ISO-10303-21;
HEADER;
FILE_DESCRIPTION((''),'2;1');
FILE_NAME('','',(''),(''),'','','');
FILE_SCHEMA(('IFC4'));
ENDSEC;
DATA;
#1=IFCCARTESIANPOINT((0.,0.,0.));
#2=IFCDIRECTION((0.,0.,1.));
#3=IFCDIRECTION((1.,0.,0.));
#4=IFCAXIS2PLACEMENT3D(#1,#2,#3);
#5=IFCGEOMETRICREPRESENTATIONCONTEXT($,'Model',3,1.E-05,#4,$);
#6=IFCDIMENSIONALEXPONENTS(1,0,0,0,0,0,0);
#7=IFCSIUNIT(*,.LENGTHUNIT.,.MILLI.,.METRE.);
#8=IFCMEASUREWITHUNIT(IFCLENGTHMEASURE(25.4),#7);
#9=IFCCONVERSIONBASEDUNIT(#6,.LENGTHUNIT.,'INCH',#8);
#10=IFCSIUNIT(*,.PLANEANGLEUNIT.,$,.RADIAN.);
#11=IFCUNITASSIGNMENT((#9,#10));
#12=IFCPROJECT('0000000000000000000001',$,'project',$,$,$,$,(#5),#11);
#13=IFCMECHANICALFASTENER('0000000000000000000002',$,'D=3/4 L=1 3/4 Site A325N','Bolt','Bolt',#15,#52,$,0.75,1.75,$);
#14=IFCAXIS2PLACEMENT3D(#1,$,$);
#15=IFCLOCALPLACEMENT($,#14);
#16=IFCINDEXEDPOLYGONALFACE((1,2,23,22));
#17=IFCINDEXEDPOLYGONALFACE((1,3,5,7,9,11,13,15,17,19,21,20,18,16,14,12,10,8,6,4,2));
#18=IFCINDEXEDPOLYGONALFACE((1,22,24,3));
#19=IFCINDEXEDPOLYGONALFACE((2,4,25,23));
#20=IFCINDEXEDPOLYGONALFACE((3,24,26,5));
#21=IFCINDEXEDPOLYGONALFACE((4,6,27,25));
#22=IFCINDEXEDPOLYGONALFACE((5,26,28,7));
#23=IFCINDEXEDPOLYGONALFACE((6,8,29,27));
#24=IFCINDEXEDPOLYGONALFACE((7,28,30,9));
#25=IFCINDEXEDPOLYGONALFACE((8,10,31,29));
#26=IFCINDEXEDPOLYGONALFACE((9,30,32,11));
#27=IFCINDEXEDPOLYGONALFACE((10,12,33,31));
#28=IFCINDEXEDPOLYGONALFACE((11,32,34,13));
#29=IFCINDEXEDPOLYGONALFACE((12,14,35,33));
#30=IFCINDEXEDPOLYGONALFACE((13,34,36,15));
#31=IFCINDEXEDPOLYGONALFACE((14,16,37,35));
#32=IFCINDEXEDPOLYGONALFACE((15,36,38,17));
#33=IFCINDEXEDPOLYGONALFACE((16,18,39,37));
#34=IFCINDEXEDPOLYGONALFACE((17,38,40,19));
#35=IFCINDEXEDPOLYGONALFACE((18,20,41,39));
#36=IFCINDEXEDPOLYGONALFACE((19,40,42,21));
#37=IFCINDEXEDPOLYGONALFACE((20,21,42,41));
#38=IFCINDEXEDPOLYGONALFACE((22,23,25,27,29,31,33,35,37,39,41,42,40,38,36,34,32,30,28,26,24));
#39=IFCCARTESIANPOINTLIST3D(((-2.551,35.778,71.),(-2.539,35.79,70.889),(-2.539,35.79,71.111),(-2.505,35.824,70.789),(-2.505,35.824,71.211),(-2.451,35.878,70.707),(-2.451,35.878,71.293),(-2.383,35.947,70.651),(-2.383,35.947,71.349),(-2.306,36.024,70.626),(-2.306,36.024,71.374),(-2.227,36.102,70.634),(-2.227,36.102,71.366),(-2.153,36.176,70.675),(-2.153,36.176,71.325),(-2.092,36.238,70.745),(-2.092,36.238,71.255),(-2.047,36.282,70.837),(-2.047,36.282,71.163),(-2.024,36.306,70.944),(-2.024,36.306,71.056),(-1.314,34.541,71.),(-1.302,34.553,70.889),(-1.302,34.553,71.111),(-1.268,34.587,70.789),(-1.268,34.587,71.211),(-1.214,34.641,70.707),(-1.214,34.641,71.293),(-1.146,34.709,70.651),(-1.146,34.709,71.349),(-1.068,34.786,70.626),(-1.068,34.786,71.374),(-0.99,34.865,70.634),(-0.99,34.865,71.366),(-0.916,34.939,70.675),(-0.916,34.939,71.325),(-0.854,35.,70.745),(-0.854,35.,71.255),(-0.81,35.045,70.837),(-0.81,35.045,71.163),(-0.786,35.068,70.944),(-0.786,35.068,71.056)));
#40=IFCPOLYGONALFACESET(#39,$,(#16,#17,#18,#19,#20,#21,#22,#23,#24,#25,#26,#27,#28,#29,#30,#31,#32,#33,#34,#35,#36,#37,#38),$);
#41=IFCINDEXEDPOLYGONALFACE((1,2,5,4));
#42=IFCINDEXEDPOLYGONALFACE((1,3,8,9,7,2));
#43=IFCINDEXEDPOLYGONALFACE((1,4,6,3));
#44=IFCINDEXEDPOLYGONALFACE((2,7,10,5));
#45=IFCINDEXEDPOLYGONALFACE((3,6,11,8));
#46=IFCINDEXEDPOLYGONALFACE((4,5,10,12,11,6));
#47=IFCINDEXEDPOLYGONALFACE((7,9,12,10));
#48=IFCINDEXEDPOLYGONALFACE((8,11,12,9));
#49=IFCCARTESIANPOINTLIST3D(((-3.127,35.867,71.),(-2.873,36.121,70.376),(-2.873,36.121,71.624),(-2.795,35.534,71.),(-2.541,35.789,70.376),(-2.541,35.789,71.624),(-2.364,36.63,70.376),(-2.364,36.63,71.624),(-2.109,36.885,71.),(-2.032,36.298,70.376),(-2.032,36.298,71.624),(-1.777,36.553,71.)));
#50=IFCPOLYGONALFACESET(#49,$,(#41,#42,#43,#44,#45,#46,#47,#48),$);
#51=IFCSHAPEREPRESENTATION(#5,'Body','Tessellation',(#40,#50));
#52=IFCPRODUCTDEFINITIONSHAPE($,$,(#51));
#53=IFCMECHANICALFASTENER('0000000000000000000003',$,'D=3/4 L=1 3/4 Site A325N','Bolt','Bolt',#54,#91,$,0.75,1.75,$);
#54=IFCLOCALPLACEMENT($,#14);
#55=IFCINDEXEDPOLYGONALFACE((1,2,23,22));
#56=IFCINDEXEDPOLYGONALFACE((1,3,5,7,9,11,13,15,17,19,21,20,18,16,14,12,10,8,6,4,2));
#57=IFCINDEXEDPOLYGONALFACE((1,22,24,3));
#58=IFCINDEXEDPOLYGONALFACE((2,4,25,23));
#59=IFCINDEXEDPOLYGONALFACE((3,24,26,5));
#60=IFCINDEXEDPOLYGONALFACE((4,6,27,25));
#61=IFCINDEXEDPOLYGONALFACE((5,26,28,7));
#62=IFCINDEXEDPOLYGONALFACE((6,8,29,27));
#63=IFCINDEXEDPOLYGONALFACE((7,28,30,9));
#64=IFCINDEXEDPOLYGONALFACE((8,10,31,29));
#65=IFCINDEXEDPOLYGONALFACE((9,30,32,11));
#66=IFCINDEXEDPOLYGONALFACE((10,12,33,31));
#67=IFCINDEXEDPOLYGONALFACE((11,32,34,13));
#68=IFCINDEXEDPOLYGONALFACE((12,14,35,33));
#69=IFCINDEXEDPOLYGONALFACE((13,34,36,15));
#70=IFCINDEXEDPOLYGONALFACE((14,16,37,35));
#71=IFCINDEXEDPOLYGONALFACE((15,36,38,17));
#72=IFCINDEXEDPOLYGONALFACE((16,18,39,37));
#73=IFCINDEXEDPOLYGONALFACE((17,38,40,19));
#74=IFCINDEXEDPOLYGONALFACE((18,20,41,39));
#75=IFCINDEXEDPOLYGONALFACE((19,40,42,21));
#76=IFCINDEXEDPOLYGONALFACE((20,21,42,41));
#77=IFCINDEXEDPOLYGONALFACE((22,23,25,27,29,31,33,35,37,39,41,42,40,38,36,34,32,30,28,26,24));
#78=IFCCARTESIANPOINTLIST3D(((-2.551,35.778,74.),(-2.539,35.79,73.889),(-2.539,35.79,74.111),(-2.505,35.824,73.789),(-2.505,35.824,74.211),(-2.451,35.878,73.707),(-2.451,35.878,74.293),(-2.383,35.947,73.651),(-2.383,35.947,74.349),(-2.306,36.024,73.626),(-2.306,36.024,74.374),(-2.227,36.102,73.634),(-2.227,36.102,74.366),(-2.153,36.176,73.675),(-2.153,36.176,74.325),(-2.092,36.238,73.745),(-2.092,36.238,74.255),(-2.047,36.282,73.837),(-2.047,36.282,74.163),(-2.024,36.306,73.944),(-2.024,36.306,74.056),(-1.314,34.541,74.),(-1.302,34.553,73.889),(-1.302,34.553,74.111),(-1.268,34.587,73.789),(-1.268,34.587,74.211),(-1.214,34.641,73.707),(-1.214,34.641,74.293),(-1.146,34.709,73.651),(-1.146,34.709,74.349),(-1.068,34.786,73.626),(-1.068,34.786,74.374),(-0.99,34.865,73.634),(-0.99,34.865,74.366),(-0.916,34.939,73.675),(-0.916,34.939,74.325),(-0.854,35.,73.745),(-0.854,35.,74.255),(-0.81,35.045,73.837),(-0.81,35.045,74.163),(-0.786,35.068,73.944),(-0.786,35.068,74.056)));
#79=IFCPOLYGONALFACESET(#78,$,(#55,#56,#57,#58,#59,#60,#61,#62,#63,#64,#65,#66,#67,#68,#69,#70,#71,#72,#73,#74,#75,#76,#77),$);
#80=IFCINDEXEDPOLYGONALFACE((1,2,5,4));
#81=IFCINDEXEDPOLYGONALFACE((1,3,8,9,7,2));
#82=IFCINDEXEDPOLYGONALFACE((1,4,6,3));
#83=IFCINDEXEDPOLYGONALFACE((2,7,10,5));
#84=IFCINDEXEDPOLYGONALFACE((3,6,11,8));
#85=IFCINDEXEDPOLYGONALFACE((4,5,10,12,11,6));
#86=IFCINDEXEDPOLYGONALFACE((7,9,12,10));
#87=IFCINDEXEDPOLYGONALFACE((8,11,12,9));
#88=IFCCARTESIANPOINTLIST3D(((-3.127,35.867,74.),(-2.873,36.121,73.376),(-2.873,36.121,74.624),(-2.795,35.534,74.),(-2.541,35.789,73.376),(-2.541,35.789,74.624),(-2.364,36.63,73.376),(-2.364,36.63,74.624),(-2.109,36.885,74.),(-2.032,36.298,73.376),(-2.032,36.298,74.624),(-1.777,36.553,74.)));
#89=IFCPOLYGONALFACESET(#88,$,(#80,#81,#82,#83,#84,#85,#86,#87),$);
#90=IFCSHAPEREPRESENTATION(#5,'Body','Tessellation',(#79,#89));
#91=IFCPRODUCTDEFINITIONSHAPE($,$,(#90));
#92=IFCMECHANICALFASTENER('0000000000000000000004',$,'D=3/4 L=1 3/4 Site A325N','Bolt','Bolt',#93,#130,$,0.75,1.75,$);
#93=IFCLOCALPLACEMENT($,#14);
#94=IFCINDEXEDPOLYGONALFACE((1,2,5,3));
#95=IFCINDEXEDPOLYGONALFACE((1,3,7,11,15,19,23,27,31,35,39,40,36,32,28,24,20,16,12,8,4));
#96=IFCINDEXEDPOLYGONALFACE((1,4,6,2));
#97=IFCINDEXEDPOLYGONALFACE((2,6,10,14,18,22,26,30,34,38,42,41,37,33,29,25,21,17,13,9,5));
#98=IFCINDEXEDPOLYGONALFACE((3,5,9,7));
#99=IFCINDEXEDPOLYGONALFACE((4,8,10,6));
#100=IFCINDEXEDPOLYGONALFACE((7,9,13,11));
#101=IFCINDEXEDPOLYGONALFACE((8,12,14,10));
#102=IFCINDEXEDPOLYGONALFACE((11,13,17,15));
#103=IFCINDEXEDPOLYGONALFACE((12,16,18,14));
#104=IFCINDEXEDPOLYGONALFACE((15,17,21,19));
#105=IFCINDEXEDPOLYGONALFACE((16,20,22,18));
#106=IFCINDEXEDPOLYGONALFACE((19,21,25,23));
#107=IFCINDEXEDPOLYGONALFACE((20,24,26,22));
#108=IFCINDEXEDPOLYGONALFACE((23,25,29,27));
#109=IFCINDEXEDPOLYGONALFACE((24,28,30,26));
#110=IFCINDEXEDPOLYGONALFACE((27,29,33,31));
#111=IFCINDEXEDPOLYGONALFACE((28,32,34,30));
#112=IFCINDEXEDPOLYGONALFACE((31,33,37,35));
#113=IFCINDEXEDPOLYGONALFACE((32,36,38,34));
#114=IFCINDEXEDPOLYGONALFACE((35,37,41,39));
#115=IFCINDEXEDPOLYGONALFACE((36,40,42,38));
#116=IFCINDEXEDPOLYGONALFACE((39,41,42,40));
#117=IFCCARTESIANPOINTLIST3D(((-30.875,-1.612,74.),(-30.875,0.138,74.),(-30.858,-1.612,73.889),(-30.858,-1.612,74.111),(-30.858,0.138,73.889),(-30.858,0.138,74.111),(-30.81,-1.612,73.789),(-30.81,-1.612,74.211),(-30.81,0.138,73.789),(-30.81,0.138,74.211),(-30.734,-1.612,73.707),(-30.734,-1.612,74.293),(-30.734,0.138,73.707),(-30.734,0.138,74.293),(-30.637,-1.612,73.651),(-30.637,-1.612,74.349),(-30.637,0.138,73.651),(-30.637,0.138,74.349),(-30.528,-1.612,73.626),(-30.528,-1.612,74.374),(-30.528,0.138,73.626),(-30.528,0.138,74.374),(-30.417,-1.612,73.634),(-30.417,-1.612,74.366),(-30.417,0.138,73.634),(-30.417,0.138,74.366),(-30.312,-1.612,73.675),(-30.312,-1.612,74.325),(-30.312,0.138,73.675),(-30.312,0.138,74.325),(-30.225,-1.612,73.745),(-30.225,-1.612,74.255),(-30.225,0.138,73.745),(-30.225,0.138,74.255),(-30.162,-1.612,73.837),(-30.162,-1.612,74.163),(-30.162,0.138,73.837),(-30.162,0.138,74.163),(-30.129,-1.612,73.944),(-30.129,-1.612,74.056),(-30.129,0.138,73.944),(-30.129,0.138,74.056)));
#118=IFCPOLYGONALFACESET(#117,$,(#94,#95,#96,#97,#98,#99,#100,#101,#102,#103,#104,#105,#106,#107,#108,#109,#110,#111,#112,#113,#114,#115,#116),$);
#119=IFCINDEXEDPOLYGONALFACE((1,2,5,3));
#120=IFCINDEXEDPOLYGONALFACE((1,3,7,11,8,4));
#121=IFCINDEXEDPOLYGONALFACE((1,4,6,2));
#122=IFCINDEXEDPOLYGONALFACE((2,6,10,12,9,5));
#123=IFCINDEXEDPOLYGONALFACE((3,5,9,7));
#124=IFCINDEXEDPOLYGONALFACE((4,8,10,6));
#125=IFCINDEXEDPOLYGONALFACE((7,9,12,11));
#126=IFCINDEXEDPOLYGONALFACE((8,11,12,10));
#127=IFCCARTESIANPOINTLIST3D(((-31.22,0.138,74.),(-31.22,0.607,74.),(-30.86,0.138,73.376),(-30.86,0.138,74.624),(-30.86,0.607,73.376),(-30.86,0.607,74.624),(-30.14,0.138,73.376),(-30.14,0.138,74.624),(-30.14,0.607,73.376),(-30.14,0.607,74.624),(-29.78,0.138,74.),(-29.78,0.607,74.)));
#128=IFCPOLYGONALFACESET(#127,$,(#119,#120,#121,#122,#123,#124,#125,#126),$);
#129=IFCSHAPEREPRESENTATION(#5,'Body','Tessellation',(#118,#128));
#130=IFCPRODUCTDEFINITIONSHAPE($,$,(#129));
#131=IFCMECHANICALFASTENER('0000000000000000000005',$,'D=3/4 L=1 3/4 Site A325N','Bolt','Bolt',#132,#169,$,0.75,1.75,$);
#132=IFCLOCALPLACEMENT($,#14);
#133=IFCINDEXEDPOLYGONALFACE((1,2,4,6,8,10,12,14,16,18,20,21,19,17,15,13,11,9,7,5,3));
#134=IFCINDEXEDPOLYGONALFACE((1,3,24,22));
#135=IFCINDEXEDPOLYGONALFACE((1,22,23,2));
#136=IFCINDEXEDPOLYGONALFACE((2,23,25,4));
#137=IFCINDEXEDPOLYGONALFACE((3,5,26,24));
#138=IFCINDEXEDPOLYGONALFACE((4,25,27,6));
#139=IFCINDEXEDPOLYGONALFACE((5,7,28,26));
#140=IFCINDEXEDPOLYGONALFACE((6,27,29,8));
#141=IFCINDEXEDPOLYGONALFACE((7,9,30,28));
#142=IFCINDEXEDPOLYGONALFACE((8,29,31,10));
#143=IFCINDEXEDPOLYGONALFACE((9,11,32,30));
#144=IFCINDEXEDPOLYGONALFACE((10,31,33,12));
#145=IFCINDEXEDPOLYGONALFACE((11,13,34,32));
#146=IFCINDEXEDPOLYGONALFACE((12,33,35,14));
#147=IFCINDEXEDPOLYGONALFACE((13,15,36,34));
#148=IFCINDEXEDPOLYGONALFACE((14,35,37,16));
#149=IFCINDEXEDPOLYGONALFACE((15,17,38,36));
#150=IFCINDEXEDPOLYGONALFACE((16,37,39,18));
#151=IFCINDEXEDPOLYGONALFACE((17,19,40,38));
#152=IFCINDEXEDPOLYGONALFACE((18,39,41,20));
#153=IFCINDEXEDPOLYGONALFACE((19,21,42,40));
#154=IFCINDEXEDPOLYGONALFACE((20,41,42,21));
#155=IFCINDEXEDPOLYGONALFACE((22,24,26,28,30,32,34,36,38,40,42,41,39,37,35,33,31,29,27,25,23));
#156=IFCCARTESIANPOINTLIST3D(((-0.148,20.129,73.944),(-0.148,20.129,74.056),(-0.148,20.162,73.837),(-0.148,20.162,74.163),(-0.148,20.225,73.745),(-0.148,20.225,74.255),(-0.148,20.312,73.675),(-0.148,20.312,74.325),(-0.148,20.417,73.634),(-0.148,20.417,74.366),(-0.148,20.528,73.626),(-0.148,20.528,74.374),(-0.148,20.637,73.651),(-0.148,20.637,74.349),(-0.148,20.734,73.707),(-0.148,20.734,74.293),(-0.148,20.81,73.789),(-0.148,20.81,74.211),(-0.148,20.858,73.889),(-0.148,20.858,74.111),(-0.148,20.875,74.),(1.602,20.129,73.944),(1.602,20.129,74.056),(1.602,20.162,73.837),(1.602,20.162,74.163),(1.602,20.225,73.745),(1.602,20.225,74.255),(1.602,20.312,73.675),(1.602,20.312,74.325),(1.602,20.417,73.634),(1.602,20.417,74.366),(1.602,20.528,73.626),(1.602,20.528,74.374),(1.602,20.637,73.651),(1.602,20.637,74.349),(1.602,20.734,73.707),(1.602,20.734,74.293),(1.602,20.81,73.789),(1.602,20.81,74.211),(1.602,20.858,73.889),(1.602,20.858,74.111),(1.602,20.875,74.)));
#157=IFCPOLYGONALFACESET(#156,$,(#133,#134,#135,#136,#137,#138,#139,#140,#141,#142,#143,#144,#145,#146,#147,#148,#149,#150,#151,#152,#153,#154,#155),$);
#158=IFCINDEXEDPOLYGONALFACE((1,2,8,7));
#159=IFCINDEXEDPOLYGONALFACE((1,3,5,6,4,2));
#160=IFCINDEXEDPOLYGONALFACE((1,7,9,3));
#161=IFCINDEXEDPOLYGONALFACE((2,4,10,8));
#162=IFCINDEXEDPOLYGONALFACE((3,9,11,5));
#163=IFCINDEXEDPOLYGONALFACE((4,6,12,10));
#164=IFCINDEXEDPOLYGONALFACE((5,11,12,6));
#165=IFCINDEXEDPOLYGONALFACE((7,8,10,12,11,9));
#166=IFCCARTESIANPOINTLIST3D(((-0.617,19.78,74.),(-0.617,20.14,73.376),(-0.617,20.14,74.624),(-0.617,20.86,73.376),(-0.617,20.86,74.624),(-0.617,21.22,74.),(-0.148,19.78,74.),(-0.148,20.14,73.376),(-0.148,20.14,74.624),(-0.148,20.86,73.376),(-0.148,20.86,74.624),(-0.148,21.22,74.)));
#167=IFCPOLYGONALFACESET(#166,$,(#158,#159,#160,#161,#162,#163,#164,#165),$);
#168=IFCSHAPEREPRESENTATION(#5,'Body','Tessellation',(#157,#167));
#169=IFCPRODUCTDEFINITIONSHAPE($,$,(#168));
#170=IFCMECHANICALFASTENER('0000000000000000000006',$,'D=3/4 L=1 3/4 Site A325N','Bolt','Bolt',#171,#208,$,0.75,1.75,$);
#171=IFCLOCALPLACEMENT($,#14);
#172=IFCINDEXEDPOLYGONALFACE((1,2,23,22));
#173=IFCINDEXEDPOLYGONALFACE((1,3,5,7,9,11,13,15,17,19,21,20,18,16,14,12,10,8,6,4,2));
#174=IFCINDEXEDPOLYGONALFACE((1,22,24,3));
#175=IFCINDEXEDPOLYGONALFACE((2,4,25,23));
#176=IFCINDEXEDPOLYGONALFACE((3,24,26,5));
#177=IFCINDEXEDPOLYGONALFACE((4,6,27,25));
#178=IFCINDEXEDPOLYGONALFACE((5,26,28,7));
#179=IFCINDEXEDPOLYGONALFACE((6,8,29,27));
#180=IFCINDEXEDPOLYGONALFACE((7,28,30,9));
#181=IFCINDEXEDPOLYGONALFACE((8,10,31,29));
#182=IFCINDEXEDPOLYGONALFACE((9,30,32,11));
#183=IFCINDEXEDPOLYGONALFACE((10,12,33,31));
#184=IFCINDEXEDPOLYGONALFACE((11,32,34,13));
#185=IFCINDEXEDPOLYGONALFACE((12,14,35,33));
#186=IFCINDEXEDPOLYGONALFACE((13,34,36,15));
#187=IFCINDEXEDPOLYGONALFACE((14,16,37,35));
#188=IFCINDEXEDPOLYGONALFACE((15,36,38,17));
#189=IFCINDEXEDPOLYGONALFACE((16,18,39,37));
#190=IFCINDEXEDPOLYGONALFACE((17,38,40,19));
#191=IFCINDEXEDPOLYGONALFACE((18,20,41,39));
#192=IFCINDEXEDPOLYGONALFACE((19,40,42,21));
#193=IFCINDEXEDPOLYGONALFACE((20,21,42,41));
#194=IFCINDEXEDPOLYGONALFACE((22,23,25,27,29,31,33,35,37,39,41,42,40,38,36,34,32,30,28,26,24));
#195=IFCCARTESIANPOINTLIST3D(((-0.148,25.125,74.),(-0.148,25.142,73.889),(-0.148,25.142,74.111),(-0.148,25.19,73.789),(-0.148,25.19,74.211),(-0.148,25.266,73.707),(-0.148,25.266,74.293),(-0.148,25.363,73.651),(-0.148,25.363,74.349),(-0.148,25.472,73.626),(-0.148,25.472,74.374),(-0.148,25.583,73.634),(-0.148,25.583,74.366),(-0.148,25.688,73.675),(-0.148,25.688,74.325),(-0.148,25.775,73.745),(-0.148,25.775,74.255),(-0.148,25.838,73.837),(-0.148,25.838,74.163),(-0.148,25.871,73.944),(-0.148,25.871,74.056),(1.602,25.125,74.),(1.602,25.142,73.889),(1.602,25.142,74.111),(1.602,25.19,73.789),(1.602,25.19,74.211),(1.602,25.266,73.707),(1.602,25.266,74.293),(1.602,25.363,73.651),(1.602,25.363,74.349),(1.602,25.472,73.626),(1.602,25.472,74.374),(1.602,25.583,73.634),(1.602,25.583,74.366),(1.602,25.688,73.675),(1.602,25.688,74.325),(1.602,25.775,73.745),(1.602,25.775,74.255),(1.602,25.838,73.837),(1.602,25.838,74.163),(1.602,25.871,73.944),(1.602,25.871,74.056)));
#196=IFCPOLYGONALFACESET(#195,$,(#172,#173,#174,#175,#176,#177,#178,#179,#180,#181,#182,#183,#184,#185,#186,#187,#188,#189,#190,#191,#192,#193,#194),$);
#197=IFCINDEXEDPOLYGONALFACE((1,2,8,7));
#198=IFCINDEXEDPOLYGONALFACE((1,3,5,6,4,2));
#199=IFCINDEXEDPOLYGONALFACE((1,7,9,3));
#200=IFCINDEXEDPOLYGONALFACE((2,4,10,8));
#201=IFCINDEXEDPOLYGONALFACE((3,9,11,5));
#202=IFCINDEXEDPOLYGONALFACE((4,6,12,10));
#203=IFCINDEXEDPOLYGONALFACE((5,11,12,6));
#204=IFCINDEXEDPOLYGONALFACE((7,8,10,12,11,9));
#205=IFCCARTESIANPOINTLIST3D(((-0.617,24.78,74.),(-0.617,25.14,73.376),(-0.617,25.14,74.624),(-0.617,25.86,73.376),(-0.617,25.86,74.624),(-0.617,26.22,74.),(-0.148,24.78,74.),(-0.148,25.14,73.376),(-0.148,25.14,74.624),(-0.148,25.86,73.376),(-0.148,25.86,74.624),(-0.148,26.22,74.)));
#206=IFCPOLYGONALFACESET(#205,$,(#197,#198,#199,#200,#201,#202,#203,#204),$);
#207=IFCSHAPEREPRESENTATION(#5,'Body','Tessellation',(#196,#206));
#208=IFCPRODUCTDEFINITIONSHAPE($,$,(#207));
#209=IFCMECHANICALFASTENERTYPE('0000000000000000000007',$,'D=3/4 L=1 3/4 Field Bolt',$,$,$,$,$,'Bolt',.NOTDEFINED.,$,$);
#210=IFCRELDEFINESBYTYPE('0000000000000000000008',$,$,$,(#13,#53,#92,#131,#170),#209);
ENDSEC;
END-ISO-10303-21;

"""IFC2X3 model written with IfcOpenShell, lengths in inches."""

from ifc_helpers import new_model, entity, si_unit, converted_unit, frame, origin_with_axes, origin_2d_with_axis, place, context, project, polyline, circle, outline, extrude, source, transform, mapped, type_object, type_shapes, element, save


model = new_model("IFC2X3")

# Units and contexts
model_context = context("Model", 3, precision=1e-05, world=origin_with_axes())
ifc_project = project(units=[converted_unit("LENGTHUNIT", "INCH", entity("IfcLengthMeasure", 25.4), si_unit("LENGTHUNIT", "METRE", prefix="MILLI"), dimensions=[1, 0, 0, 0, 0, 0, 0]), si_unit("PLANEANGLEUNIT", "RADIAN")], contexts=[model_context])

# Mechanical fasteners
mechanical_fastener_type_1 = type_object("IfcMechanicalFastenerType", Name="D=3/4 L=1 3/4 Field Bolt", ElementType="Bolt")
shared_shape_1 = source(origin_with_axes(), model_context, "Body", "SweptSolid", [
    extrude(circle(Radius=0.375, at=origin_2d_with_axis()), frame((0.0, 0.0, 0.0), z_axis=(1.0, 0.0, 0.0), x_axis=(0.0, 1.0, 0.0)), (0.0, 0.0, 1.0), 1.75),
    extrude(outline(polyline([(-0.72, 0.0), (-0.36, 0.624), (0.36, 0.624), (0.72, 0.0), (0.36, -0.624), (-0.36, -0.624), (-0.72, 0.0)])), frame((0.0, 0.0, 0.0), z_axis=(1.0, 0.0, 0.0), x_axis=(0.0, 1.0, 0.0)), (0.0, 0.0, -1.0), 0.47),
])
type_shapes(mechanical_fastener_type_1, [shared_shape_1])
placement_1 = place(None, origin_with_axes())
placement_2 = place(placement_1, origin_with_axes())
placement_3 = place(placement_2, frame((-38.0, 0.0, 77.0), z_axis=(0.0, 0.0, 1.0), x_axis=(0.707107, 0.707107, 0.0)))
placement_4 = place(placement_3, frame((50.74, 0.233, -3.0), z_axis=(0.0, 0.0, -1.0), x_axis=(0.0, -1.0, 0.0)))
for number, where, z_axis, x_axis, name in (
    (1, (0.0, 0.0, 3.0), (0.0, 0.0, 1.0), (1.0, 0.0, 0.0), "D=3/4 L=1 3/4 Site A325N"),
    (2, (0.0, 0.0, 0.0), (0.0, 0.0, 1.0), (1.0, 0.0, 0.0), "D=3/4 L=1 3/4 Site A325N"),
):
    element("IfcMechanicalFastener", number, at=place(placement_4, frame(where, z_axis=z_axis, x_axis=x_axis)), type_object=mechanical_fastener_type_1, Name=name, Description="Bolt", ObjectType="Bolt", NominalDiameter=0.75, NominalLength=1.75, context=model_context, shape_type="MappedRepresentation", body=[
        mapped(shared_shape_1, transform((0.0, 0.0, 0.0), scale=1.0)),
    ])
placement_5 = place(placement_2, frame((-33.0, 0.0, 77.0), z_axis=(0.0, 0.0, 1.0), x_axis=(0.0, -1.0, 0.0)))
placement_6 = place(placement_5, frame((-0.138, 2.5, -3.0), z_axis=(0.0, 0.0, -1.0), x_axis=(1.0, 0.0, 0.0)))
mechanical_fastener_1_placement = place(placement_6, origin_with_axes())
element("IfcMechanicalFastener", 3, at=mechanical_fastener_1_placement, type_object=mechanical_fastener_type_1, Name="D=3/4 L=1 3/4 Site A325N", Description="Bolt", ObjectType="Bolt", NominalDiameter=0.75, NominalLength=1.75, context=model_context, shape_type="MappedRepresentation", body=[
    mapped(shared_shape_1, transform((0.0, 0.0, 0.0), scale=1.0)),
])
placement_7 = place(placement_2, frame((0.0, 23.0, 82.5), z_axis=(0.0, 0.0, 1.0), x_axis=(1.0, 0.0, 0.0)))
placement_8 = place(placement_7, frame((-0.148, -2.5, -8.5), z_axis=(0.0, 0.0, 1.0), x_axis=(1.0, 0.0, 0.0)))
mechanical_fastener_2_placement = place(placement_8, origin_with_axes())
element("IfcMechanicalFastener", 4, at=mechanical_fastener_2_placement, type_object=mechanical_fastener_type_1, Name="D=3/4 L=1 3/4 Site A325N", Description="Bolt", ObjectType="Bolt", NominalDiameter=0.75, NominalLength=1.75, context=model_context, shape_type="MappedRepresentation", body=[
    mapped(shared_shape_1, transform((0.0, 0.0, 0.0), scale=1.0)),
])
placement_9 = place(placement_7, frame((-0.148, 2.5, -5.5), z_axis=(0.0, 0.0, -1.0), x_axis=(1.0, 0.0, 0.0)))
mechanical_fastener_3_placement = place(placement_9, frame((0.0, 0.0, 3.0), z_axis=(0.0, 0.0, 1.0), x_axis=(1.0, 0.0, 0.0)))
element("IfcMechanicalFastener", 5, at=mechanical_fastener_3_placement, type_object=mechanical_fastener_type_1, Name="D=3/4 L=1 3/4 Site A325N", Description="Bolt", ObjectType="Bolt", NominalDiameter=0.75, NominalLength=1.75, context=model_context, shape_type="MappedRepresentation", body=[
    mapped(shared_shape_1, transform((0.0, 0.0, 0.0), scale=1.0)),
])

save(model, "model.ifc")
